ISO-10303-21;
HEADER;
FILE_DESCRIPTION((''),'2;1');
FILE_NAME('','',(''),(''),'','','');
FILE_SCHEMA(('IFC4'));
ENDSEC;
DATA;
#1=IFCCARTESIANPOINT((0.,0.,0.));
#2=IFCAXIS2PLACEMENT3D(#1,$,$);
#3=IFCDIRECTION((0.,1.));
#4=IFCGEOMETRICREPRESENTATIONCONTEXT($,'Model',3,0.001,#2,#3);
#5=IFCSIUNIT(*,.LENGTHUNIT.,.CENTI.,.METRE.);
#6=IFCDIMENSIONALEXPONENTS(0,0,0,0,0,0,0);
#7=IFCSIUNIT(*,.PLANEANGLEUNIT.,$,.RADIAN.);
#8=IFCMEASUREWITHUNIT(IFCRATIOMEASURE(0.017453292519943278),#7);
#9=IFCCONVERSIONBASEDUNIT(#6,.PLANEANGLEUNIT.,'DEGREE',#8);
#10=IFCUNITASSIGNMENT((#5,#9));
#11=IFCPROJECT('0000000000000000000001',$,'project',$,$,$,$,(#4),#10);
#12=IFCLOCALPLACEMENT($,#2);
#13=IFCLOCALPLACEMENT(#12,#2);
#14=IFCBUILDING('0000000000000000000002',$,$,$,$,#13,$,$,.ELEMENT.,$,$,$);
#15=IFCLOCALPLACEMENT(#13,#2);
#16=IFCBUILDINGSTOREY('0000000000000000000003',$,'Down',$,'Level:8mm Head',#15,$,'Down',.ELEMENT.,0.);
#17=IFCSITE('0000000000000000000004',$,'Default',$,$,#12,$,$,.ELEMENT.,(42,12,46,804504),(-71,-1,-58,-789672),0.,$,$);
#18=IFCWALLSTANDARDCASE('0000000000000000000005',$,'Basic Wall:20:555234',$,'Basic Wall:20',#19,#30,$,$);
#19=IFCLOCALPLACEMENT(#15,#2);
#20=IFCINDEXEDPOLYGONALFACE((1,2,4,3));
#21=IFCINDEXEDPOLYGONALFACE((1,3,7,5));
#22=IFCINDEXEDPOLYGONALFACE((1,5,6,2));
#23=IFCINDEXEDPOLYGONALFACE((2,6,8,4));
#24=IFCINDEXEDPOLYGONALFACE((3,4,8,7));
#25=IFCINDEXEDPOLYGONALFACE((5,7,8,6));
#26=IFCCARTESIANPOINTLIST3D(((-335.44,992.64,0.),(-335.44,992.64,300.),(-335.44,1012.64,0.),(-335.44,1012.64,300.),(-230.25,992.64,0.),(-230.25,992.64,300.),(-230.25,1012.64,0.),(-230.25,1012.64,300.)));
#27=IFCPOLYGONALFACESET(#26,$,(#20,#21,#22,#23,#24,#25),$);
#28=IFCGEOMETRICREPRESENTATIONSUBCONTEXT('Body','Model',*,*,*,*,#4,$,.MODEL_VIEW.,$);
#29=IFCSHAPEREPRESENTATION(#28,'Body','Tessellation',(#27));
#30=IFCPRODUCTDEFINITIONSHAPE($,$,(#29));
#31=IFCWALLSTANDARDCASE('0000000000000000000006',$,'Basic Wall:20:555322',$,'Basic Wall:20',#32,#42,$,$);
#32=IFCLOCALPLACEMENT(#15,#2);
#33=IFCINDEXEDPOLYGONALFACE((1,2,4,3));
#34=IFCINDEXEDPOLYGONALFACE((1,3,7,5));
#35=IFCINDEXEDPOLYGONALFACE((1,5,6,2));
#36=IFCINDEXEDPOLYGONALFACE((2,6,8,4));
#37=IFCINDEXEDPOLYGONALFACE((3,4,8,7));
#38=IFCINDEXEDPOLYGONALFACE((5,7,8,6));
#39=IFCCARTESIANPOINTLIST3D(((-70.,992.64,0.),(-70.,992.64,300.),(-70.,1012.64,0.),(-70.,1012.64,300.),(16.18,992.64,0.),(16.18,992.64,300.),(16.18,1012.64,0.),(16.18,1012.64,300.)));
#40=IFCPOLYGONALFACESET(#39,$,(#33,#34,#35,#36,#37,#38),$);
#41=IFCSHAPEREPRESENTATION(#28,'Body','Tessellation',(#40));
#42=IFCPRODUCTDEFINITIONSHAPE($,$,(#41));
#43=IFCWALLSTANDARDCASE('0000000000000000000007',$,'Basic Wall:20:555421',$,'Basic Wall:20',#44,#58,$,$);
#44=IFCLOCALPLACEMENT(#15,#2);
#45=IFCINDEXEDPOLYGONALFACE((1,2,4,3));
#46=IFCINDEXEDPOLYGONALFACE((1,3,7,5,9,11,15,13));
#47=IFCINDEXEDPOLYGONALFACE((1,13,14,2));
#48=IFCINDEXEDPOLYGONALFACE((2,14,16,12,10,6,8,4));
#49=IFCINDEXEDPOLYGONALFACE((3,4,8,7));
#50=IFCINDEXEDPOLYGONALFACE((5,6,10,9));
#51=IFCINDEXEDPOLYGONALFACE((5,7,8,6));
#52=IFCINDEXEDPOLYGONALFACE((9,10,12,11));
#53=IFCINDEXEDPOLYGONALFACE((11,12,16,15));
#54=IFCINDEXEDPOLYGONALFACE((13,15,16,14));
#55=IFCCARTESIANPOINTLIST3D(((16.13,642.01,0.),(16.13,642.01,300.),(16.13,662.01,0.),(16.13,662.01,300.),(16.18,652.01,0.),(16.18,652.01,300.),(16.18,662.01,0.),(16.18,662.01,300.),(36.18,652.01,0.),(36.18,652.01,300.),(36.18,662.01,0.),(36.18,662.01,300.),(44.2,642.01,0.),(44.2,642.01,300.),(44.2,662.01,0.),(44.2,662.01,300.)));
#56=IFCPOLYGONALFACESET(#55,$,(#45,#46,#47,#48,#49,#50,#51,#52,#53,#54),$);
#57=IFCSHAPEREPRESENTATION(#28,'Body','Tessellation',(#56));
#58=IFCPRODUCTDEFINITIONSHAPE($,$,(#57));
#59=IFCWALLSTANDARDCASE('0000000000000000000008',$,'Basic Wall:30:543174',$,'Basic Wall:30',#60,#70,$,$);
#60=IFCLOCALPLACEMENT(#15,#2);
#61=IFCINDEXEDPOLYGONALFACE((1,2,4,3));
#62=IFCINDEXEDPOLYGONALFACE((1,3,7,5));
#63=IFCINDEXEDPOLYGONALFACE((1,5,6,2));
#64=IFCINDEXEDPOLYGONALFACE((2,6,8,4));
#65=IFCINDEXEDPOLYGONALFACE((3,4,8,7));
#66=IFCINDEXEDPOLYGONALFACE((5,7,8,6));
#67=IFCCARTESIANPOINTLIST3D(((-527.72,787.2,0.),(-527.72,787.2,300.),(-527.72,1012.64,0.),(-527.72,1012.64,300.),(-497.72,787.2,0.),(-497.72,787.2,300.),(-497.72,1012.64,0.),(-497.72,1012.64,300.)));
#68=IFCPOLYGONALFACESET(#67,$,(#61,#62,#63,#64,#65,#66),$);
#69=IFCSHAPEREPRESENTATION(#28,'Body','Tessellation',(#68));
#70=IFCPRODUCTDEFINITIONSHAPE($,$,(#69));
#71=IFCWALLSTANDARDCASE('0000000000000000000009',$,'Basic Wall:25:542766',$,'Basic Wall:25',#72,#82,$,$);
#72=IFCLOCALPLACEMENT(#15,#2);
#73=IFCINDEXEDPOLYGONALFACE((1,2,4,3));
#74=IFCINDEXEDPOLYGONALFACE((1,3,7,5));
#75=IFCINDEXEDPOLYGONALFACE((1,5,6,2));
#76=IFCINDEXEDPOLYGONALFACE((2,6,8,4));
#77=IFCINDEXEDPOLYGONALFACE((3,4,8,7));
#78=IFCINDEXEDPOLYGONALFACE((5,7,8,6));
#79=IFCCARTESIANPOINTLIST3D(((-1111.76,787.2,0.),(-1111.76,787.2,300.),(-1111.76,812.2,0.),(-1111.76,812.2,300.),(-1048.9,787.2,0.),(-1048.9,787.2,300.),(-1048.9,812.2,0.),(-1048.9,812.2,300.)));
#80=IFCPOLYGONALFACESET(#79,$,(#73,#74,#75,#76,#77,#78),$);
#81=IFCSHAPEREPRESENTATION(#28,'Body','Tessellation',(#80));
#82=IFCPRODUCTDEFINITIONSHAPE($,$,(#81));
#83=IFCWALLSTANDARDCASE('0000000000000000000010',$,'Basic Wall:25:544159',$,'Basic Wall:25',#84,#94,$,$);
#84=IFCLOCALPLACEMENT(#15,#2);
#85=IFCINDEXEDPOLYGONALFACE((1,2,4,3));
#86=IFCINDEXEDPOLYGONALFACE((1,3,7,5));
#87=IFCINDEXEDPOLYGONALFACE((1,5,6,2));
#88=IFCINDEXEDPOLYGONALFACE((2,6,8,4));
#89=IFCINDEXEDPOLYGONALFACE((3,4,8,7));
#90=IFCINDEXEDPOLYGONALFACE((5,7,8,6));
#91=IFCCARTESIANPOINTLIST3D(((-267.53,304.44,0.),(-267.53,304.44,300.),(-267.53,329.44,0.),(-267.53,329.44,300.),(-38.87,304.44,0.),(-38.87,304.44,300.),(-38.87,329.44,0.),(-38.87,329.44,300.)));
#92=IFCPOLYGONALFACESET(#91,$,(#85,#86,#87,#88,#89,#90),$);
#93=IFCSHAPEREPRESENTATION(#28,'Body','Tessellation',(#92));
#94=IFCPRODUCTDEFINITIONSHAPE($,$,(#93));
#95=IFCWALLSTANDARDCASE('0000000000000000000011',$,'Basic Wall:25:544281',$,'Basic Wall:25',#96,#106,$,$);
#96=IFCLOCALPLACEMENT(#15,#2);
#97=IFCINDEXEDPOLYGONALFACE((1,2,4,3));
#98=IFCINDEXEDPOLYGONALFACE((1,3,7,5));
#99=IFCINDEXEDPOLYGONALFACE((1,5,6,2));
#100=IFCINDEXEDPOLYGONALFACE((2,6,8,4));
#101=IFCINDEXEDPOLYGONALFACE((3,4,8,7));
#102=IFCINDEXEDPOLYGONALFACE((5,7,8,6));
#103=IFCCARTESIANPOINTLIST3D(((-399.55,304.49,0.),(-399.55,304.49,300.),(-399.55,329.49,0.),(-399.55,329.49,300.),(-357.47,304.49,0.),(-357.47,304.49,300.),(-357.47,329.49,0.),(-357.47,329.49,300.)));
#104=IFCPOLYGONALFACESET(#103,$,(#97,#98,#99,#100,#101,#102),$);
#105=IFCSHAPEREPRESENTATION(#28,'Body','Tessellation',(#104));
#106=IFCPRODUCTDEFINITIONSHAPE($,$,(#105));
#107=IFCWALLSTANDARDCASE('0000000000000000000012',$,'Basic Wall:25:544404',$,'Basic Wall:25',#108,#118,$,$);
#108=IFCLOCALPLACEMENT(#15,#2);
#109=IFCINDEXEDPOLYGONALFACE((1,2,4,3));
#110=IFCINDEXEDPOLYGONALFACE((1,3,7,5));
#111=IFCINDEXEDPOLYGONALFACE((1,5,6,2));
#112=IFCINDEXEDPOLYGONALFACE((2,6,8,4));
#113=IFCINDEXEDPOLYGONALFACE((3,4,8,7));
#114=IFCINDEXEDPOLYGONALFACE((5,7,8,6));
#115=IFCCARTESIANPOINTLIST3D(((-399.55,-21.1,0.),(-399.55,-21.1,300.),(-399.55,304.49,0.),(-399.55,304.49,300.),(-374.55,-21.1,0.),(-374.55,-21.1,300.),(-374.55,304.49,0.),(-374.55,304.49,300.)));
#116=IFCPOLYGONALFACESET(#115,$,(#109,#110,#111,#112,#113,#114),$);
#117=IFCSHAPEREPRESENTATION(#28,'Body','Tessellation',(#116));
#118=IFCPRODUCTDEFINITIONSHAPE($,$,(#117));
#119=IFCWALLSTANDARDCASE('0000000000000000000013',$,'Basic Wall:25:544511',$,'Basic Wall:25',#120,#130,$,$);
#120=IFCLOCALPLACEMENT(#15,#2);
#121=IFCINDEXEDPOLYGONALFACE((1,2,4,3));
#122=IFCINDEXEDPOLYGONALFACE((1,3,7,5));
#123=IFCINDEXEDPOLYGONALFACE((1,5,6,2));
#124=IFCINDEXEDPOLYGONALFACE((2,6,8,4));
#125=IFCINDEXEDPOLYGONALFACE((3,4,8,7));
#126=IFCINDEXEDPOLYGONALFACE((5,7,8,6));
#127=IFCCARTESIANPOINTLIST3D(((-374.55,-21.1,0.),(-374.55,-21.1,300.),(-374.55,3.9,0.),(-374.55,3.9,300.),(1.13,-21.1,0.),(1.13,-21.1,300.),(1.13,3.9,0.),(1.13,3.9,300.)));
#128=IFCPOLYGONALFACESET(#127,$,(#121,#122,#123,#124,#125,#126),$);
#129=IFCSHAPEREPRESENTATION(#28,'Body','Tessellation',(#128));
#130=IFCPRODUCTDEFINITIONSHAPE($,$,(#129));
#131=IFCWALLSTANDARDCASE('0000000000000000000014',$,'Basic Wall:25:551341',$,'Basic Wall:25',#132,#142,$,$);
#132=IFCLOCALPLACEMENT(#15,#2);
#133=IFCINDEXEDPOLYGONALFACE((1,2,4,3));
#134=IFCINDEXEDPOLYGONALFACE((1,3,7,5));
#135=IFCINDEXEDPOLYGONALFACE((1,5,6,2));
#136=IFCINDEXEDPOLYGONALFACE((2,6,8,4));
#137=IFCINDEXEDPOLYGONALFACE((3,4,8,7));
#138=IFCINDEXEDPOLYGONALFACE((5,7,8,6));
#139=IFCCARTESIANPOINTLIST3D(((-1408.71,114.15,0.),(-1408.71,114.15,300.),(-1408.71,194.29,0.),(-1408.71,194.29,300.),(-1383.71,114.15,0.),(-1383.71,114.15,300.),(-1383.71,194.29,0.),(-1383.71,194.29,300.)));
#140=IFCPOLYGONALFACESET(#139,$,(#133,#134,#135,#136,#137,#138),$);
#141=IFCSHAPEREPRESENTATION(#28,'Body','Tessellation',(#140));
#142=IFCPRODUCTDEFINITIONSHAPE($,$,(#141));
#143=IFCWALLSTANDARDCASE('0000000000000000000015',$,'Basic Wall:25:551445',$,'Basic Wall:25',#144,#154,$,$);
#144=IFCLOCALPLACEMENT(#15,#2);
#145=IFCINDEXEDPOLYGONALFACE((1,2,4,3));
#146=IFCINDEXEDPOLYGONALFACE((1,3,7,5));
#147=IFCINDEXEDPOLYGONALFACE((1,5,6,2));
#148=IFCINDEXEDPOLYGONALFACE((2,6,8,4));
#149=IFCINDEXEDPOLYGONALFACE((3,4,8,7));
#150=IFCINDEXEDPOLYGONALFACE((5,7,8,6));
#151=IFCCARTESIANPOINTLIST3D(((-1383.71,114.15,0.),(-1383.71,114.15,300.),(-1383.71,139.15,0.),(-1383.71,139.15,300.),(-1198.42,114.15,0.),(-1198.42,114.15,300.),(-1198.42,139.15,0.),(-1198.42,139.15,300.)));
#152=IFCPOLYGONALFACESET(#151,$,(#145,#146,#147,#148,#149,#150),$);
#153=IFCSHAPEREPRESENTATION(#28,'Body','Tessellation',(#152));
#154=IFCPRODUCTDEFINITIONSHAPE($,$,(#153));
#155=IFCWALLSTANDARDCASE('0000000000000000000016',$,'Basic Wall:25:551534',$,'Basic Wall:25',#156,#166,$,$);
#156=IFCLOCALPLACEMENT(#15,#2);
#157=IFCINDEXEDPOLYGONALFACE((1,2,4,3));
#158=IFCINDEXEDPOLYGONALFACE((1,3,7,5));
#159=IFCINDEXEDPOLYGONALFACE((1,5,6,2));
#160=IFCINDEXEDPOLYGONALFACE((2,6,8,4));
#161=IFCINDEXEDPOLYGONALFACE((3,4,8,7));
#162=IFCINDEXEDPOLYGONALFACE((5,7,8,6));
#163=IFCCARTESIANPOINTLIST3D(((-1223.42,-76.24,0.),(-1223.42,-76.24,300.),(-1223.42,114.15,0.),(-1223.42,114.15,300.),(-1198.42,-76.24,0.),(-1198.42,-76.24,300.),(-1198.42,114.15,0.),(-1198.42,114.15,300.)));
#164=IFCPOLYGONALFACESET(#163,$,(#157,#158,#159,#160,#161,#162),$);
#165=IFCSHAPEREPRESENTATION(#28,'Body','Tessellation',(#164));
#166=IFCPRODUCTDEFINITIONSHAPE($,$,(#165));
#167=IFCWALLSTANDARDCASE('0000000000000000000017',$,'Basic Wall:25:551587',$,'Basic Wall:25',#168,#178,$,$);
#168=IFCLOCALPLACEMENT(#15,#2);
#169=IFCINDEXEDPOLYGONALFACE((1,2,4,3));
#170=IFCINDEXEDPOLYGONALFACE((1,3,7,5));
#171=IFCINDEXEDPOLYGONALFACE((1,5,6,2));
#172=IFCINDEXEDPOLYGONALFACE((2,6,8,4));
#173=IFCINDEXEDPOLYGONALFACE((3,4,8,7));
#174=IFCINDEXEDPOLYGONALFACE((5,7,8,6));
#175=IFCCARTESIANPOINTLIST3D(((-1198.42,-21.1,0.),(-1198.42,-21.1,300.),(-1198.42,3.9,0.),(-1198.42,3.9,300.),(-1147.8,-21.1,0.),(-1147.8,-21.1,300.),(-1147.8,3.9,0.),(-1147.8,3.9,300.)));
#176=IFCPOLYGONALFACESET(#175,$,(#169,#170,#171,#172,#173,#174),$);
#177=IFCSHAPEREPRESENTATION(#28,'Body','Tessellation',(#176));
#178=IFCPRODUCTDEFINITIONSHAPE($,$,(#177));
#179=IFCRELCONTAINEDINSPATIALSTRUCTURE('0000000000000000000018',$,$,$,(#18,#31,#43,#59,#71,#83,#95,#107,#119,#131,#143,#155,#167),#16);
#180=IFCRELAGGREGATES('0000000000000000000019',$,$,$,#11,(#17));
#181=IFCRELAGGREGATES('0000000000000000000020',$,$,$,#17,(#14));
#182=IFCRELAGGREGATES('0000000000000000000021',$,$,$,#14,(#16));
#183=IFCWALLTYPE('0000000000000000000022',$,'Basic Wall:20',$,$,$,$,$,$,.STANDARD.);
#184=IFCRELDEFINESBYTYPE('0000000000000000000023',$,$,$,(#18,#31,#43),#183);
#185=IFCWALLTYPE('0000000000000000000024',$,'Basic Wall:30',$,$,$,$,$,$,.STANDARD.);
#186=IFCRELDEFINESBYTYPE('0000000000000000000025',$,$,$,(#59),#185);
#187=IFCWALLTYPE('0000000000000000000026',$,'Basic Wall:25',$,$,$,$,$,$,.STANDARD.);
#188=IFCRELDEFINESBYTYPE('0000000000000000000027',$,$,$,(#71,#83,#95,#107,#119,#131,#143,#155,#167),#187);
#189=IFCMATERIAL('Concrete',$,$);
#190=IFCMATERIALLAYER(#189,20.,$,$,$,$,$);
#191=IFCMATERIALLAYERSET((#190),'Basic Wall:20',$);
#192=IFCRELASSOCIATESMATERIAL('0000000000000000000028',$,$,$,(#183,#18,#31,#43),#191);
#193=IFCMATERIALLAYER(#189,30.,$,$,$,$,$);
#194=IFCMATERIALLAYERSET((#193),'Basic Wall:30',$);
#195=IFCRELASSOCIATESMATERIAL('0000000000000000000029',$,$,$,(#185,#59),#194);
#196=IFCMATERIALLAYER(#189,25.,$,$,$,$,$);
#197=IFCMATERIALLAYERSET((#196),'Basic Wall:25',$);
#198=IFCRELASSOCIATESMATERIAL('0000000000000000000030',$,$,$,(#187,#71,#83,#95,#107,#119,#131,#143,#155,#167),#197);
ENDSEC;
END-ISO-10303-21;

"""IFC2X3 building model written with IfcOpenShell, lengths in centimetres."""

from ifc_helpers import new_model, entity, si_unit, converted_unit, direction, frame, frame_2d, origin, place, context, subcontext, project, spatial, polyline, rectangle, extrude, clip, bounded_halfspace, material, layer, layer_set, layer_usage, type_object, element, save


model = new_model("IFC2X3")

# Units and contexts
model_context = context("Model", 3, precision=0.001, world=origin(), true_north=direction((0.0, 1.0)))
body_context = subcontext(model_context, "Body", "Model", "MODEL_VIEW")
ifc_project = project(units=[si_unit("LENGTHUNIT", "METRE", prefix="CENTI"), converted_unit("PLANEANGLEUNIT", "DEGREE", entity("IfcRatioMeasure", 0.017453292519943278), si_unit("PLANEANGLEUNIT", "RADIAN"), dimensions=[0, 0, 0, 0, 0, 0, 0])], contexts=[model_context])

# Site, building, storey
site_placement = place(None, origin())
site = spatial("IfcSite", under=ifc_project, at=site_placement, Name="Default", CompositionType="ELEMENT", RefLatitude=(42, 12, 46, 804504), RefLongitude=(-71, -1, -58, -789672), RefElevation=0.0)
building_placement = place(site_placement, origin())
building = spatial("IfcBuilding", under=site, at=building_placement, CompositionType="ELEMENT")
storey_placement = place(building_placement, origin())
storey = spatial("IfcBuildingStorey", under=building, at=storey_placement, Name="Down", ObjectType="Level:8mm Head", LongName="Down", CompositionType="ELEMENT", Elevation=0.0)

# Walls
ifc_material = material(Name="Concrete")
ifc_layer_1 = layer(ifc_material, 20.0)
ifc_layer_set_1 = layer_set([ifc_layer_1], Name="Basic Wall:20")
wall_type_1 = type_object("IfcWallType", Name="Basic Wall:20", PredefinedType="STANDARD", material=ifc_layer_set_1)
ifc_layer_usage_1 = layer_usage(ifc_layer_set_1, "AXIS2", "NEGATIVE", 10.0)
wall_1_placement = place(storey_placement, frame((-335.44, 1002.64, 0.0)))
element("IfcWallStandardCase", 1, at=wall_1_placement, inside=storey, type_object=wall_type_1, material=ifc_layer_usage_1, Name="Basic Wall:20:555234", ObjectType="Basic Wall:20", context=body_context, shape_type="SweptSolid", body=[
    extrude(rectangle(XDim=105.2, YDim=20.0, at=frame_2d((52.6, 0.0), x_axis=(-1.0, 0.0))), origin(), (0.0, 0.0, 1.0), 300.0),
])
ifc_layer_usage_2 = layer_usage(ifc_layer_set_1, "AXIS2", "NEGATIVE", 10.0)
wall_2_placement = place(storey_placement, frame((-70.0, 1002.64, 0.0)))
element("IfcWallStandardCase", 2, at=wall_2_placement, inside=storey, type_object=wall_type_1, material=ifc_layer_usage_2, Name="Basic Wall:20:555322", ObjectType="Basic Wall:20", context=body_context, shape_type="SweptSolid", body=[
    extrude(rectangle(XDim=86.19, YDim=20.0, at=frame_2d((43.09, 0.0), x_axis=(-1.0, 0.0))), origin(), (0.0, 0.0, 1.0), 300.0),
])
ifc_layer_usage_3 = layer_usage(ifc_layer_set_1, "AXIS2", "POSITIVE", -10.0)
wall_3_placement = place(storey_placement, frame((16.13, 652.01, 0.0)))
element("IfcWallStandardCase", 3, at=wall_3_placement, inside=storey, type_object=wall_type_1, material=ifc_layer_usage_3, Name="Basic Wall:20:555421", ObjectType="Basic Wall:20", context=body_context, shape_type="Clipping", body=[
    clip(extrude(rectangle(XDim=28.07, YDim=20.0, at=frame_2d((14.03, 0.0), x_axis=(-1.0, 0.0))), origin(), (0.0, 0.0, 1.0), 300.0), bounded_halfspace(frame((0.05, 0.0, 0.0), z_axis=(0.0, -1.0, 0.0), x_axis=(1.0, 0.0, 0.0)), True, frame((0.05, 0.0, 0.0), z_axis=(0.0, -1.0, 0.0), x_axis=(1.0, 0.0, 0.0)), polyline([(0.0, 0.0), (20.0, 0.0), (20.0, 300.0), (0.0, 300.0), (0.0, 0.0)]))),
])
ifc_layer_2 = layer(ifc_material, 30.0)
ifc_layer_set_2 = layer_set([ifc_layer_2], Name="Basic Wall:30")
ifc_layer_usage_4 = layer_usage(ifc_layer_set_2, "AXIS2", "POSITIVE", -15.0)
wall_type_2 = type_object("IfcWallType", Name="Basic Wall:30", PredefinedType="STANDARD", material=ifc_layer_set_2)
wall_4_placement = place(storey_placement, frame((-512.72, 787.2, 0.0), z_axis=(0.0, 0.0, 1.0), x_axis=(0.0, 1.0, 0.0)))
element("IfcWallStandardCase", 4, at=wall_4_placement, inside=storey, type_object=wall_type_2, material=ifc_layer_usage_4, Name="Basic Wall:30:543174", ObjectType="Basic Wall:30", context=body_context, shape_type="SweptSolid", body=[
    extrude(rectangle(XDim=225.44, YDim=30.0, at=frame_2d((112.72, 0.0), x_axis=(-1.0, 0.0))), origin(), (0.0, 0.0, 1.0), 300.0),
])
ifc_layer_3 = layer(ifc_material, 25.0)
ifc_layer_set_3 = layer_set([ifc_layer_3], Name="Basic Wall:25")
ifc_layer_usage_5 = layer_usage(ifc_layer_set_3, "AXIS2", "NEGATIVE", 12.5)
wall_type_3 = type_object("IfcWallType", Name="Basic Wall:25", PredefinedType="STANDARD", material=ifc_layer_set_3)
wall_5_placement = place(storey_placement, frame((-1111.76, 799.7, 0.0)))
element("IfcWallStandardCase", 5, at=wall_5_placement, inside=storey, type_object=wall_type_3, material=ifc_layer_usage_5, Name="Basic Wall:25:542766", ObjectType="Basic Wall:25", context=body_context, shape_type="SweptSolid", body=[
    extrude(rectangle(XDim=62.86, YDim=25.0, at=frame_2d((31.43, 0.0), x_axis=(-1.0, 0.0))), origin(), (0.0, 0.0, 1.0), 300.0),
])
ifc_layer_usage_6 = layer_usage(ifc_layer_set_3, "AXIS2", "POSITIVE", -12.5)
wall_6_placement = place(storey_placement, frame((-38.87, 316.94, 0.0), z_axis=(0.0, 0.0, 1.0), x_axis=(-1.0, 0.0, 0.0)))
element("IfcWallStandardCase", 6, at=wall_6_placement, inside=storey, type_object=wall_type_3, material=ifc_layer_usage_6, Name="Basic Wall:25:544159", ObjectType="Basic Wall:25", context=body_context, shape_type="SweptSolid", body=[
    extrude(rectangle(XDim=228.67, YDim=25.0, at=frame_2d((114.33, 0.0), x_axis=(-1.0, 0.0))), origin(), (0.0, 0.0, 1.0), 300.0),
])
ifc_layer_usage_7 = layer_usage(ifc_layer_set_3, "AXIS2", "POSITIVE", -12.5)
wall_7_placement = place(storey_placement, frame((-357.47, 316.99, 0.0), z_axis=(0.0, 0.0, 1.0), x_axis=(-1.0, 0.0, 0.0)))
element("IfcWallStandardCase", 7, at=wall_7_placement, inside=storey, type_object=wall_type_3, material=ifc_layer_usage_7, Name="Basic Wall:25:544281", ObjectType="Basic Wall:25", context=body_context, shape_type="SweptSolid", body=[
    extrude(rectangle(XDim=42.08, YDim=25.0, at=frame_2d((21.04, 0.0), x_axis=(-1.0, 0.0))), origin(), (0.0, 0.0, 1.0), 300.0),
])
ifc_layer_usage_8 = layer_usage(ifc_layer_set_3, "AXIS2", "POSITIVE", -12.5)
wall_8_placement = place(storey_placement, frame((-387.05, 304.49, 0.0), z_axis=(0.0, 0.0, 1.0), x_axis=(0.0, -1.0, 0.0)))
element("IfcWallStandardCase", 8, at=wall_8_placement, inside=storey, type_object=wall_type_3, material=ifc_layer_usage_8, Name="Basic Wall:25:544404", ObjectType="Basic Wall:25", context=body_context, shape_type="SweptSolid", body=[
    extrude(rectangle(XDim=325.59, YDim=25.0, at=frame_2d((162.79, 0.0), x_axis=(-1.0, 0.0))), origin(), (0.0, 0.0, 1.0), 300.0),
])
ifc_layer_usage_9 = layer_usage(ifc_layer_set_3, "AXIS2", "POSITIVE", -12.5)
wall_9_placement = place(storey_placement, frame((-374.55, -8.6, 0.0)))
element("IfcWallStandardCase", 9, at=wall_9_placement, inside=storey, type_object=wall_type_3, material=ifc_layer_usage_9, Name="Basic Wall:25:544511", ObjectType="Basic Wall:25", context=body_context, shape_type="SweptSolid", body=[
    extrude(rectangle(XDim=375.68, YDim=25.0, at=frame_2d((187.84, 0.0), x_axis=(-1.0, 0.0))), origin(), (0.0, 0.0, 1.0), 300.0),
])
ifc_layer_usage_10 = layer_usage(ifc_layer_set_3, "AXIS2", "NEGATIVE", 12.5)
wall_10_placement = place(storey_placement, frame((-1396.21, 194.29, 0.0), z_axis=(0.0, 0.0, 1.0), x_axis=(0.0, -1.0, 0.0)))
element("IfcWallStandardCase", 10, at=wall_10_placement, inside=storey, type_object=wall_type_3, material=ifc_layer_usage_10, Name="Basic Wall:25:551341", ObjectType="Basic Wall:25", context=body_context, shape_type="SweptSolid", body=[
    extrude(rectangle(XDim=80.14, YDim=25.0, at=frame_2d((40.07, 0.0), x_axis=(-1.0, 0.0))), origin(), (0.0, 0.0, 1.0), 300.0),
])
ifc_layer_usage_11 = layer_usage(ifc_layer_set_3, "AXIS2", "POSITIVE", -12.5)
wall_11_placement = place(storey_placement, frame((-1383.71, 126.65, 0.0)))
element("IfcWallStandardCase", 11, at=wall_11_placement, inside=storey, type_object=wall_type_3, material=ifc_layer_usage_11, Name="Basic Wall:25:551445", ObjectType="Basic Wall:25", context=body_context, shape_type="SweptSolid", body=[
    extrude(rectangle(XDim=185.29, YDim=25.0, at=frame_2d((92.65, 0.0), x_axis=(-1.0, 0.0))), origin(), (0.0, 0.0, 1.0), 300.0),
])
ifc_layer_usage_12 = layer_usage(ifc_layer_set_3, "AXIS2", "NEGATIVE", 12.5)
wall_12_placement = place(storey_placement, frame((-1210.92, 114.15, 0.0), z_axis=(0.0, 0.0, 1.0), x_axis=(0.000013, -1.0, 0.0)))
element("IfcWallStandardCase", 12, at=wall_12_placement, inside=storey, type_object=wall_type_3, material=ifc_layer_usage_12, Name="Basic Wall:25:551534", ObjectType="Basic Wall:25", context=body_context, shape_type="SweptSolid", body=[
    extrude(rectangle(XDim=190.39, YDim=25.0, at=frame_2d((95.2, 0.0), x_axis=(-1.0, 0.0))), origin(), (0.0, 0.0, 1.0), 300.0),
])
ifc_layer_usage_13 = layer_usage(ifc_layer_set_3, "AXIS2", "POSITIVE", -12.5)
wall_13_placement = place(storey_placement, frame((-1198.42, -8.6, 0.0)))
element("IfcWallStandardCase", 13, at=wall_13_placement, inside=storey, type_object=wall_type_3, material=ifc_layer_usage_13, Name="Basic Wall:25:551587", ObjectType="Basic Wall:25", context=body_context, shape_type="SweptSolid", body=[
    extrude(rectangle(XDim=50.62, YDim=25.0, at=frame_2d((25.31, 0.0), x_axis=(-1.0, 0.0))), origin(), (0.0, 0.0, 1.0), 300.0),
])

save(model, "model.ifc")
